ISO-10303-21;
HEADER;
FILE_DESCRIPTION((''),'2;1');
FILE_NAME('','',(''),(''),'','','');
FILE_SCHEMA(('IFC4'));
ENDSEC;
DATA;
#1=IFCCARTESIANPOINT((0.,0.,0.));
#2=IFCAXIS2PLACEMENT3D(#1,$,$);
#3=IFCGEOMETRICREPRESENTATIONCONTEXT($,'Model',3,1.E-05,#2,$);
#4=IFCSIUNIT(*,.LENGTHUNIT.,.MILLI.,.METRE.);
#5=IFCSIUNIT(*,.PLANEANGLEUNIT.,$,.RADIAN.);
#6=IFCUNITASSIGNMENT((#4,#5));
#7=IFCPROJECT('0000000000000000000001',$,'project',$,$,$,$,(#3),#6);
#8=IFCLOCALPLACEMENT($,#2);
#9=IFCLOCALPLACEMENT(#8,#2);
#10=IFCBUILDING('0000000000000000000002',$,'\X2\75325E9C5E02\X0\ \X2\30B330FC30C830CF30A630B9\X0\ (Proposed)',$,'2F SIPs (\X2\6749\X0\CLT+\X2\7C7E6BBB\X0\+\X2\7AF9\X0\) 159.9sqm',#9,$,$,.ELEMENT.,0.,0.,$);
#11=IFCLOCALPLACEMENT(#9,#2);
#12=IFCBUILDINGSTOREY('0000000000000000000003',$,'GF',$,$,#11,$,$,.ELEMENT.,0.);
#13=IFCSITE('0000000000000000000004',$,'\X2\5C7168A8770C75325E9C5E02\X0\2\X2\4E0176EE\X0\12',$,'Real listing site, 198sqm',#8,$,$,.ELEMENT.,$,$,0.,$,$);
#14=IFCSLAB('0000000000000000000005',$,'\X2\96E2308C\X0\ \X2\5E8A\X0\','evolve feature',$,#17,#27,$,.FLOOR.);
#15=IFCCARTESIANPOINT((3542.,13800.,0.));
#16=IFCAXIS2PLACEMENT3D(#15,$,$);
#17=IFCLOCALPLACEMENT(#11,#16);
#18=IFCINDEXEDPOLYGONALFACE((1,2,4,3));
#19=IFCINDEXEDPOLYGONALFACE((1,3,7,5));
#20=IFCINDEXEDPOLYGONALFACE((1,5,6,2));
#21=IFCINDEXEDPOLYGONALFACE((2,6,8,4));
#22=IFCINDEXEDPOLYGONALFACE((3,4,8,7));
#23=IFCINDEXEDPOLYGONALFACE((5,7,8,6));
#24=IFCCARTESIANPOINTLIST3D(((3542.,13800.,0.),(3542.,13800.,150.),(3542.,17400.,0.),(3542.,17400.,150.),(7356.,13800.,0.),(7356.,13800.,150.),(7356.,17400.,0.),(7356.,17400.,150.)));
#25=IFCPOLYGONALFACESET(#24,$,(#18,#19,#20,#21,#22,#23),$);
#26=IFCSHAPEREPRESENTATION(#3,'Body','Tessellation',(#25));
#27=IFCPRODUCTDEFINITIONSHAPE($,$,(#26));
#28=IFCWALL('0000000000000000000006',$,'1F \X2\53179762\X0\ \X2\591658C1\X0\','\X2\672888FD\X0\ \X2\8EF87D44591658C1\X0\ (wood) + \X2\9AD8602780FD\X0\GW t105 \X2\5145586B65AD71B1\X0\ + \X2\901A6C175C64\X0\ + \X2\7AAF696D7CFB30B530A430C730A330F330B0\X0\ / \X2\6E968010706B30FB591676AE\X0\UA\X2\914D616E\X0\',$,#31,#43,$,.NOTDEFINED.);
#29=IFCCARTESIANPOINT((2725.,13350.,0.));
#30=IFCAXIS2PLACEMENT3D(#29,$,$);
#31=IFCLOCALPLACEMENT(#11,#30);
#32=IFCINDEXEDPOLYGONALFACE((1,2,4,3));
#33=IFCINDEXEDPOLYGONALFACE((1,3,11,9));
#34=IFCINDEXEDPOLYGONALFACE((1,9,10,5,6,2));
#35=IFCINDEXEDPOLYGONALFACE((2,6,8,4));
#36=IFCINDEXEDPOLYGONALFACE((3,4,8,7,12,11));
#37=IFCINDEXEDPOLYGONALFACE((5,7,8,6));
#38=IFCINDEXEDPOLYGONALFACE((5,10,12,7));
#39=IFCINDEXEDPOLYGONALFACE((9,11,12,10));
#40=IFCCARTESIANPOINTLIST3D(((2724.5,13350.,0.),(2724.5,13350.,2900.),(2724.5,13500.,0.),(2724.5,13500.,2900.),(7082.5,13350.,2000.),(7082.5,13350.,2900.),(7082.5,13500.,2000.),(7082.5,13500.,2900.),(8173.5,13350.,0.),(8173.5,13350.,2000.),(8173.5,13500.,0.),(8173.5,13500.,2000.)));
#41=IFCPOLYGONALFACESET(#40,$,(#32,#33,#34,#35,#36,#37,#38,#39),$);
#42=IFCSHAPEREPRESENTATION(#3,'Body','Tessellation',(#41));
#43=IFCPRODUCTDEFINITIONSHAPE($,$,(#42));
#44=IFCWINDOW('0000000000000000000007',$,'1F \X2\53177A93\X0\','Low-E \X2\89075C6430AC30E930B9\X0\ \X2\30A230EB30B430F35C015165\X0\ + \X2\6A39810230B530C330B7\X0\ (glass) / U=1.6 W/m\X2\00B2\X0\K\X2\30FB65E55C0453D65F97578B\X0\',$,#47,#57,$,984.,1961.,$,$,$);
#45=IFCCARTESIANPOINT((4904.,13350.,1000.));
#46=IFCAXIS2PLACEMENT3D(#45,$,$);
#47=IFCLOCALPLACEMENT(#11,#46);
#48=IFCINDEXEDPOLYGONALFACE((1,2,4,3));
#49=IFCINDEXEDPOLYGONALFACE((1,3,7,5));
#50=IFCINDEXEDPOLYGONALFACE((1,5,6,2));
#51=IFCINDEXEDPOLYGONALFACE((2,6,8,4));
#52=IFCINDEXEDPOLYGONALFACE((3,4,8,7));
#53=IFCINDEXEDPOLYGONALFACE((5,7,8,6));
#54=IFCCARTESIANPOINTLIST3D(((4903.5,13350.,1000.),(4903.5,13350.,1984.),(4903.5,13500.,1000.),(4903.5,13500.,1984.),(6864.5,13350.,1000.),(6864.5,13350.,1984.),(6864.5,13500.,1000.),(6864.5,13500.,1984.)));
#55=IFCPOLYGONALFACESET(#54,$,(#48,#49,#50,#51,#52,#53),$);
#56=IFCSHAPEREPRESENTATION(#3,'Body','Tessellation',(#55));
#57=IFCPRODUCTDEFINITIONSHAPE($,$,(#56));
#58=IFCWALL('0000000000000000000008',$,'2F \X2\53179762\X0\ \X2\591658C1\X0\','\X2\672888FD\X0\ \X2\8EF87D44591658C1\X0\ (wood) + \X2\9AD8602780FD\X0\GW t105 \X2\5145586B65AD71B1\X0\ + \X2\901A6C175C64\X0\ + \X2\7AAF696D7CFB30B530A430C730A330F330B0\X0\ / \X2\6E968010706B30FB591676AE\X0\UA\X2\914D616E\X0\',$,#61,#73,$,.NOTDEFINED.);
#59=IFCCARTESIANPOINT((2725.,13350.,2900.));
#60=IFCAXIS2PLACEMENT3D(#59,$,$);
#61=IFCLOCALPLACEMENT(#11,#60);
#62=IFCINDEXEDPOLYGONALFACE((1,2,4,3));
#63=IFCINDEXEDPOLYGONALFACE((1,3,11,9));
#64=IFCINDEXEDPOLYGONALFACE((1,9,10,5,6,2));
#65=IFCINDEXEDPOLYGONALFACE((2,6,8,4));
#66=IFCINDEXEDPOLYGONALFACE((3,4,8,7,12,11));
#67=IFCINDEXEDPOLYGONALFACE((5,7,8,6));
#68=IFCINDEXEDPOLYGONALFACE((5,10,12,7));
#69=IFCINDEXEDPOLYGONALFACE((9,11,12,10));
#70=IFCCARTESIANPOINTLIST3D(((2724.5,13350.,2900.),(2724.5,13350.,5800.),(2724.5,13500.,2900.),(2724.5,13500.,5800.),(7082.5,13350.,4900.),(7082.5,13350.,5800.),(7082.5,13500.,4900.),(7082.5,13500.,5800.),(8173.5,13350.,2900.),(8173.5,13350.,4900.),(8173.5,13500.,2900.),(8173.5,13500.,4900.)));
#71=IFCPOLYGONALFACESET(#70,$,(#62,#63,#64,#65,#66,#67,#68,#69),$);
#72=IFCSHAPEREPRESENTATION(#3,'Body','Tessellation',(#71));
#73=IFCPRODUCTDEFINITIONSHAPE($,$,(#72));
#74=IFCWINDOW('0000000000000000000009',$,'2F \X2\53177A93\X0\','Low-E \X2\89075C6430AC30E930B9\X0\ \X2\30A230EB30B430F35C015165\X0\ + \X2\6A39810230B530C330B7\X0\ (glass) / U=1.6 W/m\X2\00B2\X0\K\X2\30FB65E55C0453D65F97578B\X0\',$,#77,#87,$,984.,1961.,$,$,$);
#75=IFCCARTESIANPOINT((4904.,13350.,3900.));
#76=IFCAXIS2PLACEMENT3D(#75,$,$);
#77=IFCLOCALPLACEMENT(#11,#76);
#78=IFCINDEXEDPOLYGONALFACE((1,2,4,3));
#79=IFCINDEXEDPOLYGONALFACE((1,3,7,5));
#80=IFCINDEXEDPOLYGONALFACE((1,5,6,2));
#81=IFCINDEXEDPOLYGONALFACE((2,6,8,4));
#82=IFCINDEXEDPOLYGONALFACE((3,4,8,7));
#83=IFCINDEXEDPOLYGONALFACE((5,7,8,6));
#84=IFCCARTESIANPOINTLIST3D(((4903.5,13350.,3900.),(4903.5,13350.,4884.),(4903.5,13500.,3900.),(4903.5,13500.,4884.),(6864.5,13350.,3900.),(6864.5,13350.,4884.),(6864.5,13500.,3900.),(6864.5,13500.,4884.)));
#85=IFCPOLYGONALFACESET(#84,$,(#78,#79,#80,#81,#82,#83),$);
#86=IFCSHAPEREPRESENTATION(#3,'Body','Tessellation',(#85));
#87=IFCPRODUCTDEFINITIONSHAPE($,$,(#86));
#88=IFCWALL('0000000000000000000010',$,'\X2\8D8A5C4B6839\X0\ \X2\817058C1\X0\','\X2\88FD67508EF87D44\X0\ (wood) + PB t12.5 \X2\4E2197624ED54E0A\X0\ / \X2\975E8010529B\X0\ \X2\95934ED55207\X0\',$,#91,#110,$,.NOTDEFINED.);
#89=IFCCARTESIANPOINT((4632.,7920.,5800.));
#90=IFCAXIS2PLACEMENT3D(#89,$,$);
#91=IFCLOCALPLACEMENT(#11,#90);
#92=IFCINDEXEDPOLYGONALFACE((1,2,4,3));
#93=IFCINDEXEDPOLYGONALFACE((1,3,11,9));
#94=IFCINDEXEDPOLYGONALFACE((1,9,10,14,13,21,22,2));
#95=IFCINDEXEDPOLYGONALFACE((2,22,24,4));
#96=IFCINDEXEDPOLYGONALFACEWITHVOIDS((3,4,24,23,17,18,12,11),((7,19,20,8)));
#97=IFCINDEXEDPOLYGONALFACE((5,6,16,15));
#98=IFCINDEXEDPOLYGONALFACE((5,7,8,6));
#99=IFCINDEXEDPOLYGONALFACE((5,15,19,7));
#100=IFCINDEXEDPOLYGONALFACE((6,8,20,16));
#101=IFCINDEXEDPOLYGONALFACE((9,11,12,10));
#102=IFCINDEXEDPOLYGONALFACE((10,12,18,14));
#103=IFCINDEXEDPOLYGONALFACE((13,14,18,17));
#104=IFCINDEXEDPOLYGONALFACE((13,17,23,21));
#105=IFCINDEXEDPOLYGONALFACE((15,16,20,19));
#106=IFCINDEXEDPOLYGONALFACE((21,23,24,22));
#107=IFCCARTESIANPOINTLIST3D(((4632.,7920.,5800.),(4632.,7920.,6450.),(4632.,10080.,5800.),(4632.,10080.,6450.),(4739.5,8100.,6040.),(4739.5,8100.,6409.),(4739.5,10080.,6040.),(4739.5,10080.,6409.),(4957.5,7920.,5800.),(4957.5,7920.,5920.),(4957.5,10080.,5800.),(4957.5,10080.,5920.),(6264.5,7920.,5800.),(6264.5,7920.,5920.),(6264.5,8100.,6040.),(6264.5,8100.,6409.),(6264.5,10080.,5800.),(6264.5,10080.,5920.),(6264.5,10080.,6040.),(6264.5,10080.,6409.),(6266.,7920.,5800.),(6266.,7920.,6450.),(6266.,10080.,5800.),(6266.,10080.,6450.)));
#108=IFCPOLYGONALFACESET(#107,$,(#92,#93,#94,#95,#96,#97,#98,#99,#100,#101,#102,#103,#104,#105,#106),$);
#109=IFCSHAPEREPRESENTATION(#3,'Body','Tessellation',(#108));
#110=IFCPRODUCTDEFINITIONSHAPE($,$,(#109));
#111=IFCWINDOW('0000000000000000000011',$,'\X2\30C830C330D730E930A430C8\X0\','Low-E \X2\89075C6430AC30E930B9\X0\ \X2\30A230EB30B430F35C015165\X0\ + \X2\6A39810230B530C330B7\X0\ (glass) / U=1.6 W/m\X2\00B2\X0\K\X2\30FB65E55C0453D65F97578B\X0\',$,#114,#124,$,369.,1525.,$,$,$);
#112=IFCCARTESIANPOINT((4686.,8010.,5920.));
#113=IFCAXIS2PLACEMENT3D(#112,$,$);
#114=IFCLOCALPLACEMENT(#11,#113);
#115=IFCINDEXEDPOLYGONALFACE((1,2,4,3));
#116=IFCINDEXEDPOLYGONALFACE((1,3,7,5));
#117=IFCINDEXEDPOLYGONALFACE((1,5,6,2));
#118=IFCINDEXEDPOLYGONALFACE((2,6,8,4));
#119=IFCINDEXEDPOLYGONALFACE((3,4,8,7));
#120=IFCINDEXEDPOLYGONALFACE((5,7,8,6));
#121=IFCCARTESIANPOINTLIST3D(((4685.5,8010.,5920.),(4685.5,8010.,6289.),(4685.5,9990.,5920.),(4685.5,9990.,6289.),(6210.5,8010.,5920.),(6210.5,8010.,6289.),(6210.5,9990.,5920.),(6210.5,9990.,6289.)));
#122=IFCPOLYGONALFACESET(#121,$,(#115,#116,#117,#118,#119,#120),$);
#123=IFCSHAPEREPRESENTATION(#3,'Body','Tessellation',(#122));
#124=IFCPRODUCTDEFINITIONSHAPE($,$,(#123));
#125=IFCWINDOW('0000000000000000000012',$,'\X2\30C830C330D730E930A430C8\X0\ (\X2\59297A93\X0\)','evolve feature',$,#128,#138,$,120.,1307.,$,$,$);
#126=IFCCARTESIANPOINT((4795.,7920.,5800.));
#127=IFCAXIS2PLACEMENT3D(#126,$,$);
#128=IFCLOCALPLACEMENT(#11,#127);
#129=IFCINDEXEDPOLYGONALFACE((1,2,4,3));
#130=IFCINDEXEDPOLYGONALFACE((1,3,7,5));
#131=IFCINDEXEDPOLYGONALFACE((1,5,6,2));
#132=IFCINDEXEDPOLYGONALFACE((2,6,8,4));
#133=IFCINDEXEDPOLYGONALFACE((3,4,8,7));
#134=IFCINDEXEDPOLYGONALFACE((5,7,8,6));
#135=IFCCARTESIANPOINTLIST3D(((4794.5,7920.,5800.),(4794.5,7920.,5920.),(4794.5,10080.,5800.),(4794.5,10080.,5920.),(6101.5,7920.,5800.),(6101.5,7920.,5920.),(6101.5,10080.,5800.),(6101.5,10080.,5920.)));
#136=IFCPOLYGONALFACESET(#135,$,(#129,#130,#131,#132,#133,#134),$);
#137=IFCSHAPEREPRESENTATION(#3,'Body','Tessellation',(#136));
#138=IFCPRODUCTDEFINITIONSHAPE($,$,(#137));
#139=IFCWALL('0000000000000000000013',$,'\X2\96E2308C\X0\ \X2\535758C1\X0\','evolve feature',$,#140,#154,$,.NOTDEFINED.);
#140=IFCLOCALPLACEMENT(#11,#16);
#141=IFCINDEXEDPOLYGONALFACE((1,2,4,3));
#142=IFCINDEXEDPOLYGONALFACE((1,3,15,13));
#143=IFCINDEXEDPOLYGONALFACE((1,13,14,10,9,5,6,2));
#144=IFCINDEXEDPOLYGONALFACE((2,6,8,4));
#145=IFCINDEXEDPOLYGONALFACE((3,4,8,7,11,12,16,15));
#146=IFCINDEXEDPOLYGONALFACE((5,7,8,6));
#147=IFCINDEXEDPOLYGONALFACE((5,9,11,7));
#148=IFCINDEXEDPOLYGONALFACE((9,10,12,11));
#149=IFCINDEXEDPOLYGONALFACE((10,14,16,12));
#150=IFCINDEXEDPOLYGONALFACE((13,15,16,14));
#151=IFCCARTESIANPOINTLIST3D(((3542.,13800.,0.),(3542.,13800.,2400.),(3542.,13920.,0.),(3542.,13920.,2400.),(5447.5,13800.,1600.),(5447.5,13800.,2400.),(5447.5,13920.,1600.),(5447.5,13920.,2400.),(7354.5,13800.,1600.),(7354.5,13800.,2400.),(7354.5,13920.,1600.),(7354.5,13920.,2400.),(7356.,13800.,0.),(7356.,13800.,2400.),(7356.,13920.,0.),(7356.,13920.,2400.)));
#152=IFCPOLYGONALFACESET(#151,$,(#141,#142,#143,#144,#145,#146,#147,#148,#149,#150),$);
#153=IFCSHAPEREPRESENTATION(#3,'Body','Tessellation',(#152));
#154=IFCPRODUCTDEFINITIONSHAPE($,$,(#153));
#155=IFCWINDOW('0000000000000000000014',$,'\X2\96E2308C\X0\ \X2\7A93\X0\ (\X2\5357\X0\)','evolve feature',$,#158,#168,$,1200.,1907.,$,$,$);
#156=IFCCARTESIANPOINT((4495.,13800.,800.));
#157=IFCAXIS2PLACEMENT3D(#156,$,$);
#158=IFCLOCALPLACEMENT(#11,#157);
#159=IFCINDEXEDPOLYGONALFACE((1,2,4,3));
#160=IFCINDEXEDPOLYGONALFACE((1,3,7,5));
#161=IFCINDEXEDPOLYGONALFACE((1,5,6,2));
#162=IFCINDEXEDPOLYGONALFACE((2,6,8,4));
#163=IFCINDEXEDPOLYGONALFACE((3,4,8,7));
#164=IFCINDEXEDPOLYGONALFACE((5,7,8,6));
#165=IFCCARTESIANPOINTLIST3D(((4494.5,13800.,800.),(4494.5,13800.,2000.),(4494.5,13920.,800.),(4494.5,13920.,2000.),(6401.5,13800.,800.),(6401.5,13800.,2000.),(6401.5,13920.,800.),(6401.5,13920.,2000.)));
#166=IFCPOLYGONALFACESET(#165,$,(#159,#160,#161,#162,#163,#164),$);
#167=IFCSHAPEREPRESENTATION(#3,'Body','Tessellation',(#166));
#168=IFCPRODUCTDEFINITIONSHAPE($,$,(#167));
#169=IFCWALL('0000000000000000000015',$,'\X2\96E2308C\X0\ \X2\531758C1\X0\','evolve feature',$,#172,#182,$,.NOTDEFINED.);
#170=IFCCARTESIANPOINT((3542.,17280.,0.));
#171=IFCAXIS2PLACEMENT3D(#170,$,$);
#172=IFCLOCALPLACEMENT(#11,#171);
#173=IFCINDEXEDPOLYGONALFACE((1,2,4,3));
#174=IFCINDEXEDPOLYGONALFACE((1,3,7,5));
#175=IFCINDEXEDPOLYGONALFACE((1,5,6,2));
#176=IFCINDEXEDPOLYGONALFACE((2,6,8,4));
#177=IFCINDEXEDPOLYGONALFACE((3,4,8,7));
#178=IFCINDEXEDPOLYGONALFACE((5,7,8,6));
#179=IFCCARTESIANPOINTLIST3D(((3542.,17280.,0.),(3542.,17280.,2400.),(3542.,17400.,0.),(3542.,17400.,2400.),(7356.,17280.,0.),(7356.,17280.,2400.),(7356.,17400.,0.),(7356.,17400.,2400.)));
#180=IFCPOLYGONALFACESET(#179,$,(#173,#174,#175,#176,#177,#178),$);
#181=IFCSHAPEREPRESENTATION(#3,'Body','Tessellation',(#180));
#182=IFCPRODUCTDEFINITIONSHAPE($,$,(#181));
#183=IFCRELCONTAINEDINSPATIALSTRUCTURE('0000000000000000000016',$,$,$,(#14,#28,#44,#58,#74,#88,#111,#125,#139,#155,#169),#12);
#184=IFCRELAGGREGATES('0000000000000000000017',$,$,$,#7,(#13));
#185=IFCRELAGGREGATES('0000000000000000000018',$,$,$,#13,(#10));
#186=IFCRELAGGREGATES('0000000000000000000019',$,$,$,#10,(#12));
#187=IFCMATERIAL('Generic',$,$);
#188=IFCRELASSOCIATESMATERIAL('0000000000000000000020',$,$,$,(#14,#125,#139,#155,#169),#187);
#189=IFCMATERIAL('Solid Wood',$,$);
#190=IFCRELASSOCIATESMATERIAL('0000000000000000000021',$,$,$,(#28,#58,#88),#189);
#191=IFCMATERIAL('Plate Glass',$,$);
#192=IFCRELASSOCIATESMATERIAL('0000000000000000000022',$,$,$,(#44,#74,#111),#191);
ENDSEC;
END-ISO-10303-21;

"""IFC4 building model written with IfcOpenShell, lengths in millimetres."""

from ifc_helpers import new_model, si_unit, frame, frame_2d, origin, place, context, project, spatial, rectangle, extrude, material, element, fill, save


model = new_model("IFC4")

# Units and contexts
model_context = context("Model", 3, precision=1e-05, world=origin())
ifc_project = project(units=[si_unit("LENGTHUNIT", "METRE", prefix="MILLI"), si_unit("PLANEANGLEUNIT", "RADIAN")], contexts=[model_context])

# Site, building, storey
site_placement = place(None, origin())
site = spatial("IfcSite", under=ifc_project, at=site_placement, Name="山梨県甲府市2丁目12", ObjectType="Real listing site, 198sqm", CompositionType="ELEMENT", RefElevation=0.0)
building_placement = place(site_placement, origin())
building = spatial("IfcBuilding", under=site, at=building_placement, Name="甲府市 コートハウス (Proposed)", ObjectType="2F SIPs (杉CLT+籾殻+竹) 159.9sqm", CompositionType="ELEMENT", ElevationOfRefHeight=0.0, ElevationOfTerrain=0.0)
storey_placement = place(building_placement, origin())
storey = spatial("IfcBuildingStorey", under=building, at=storey_placement, Name="GF", CompositionType="ELEMENT", Elevation=0.0)

# Slab
ifc_material_1 = material(Name="Generic")
slab_placement = place(storey_placement, frame((3542.0, 13800.0, 0.0)))
element("IfcSlab", 1, at=slab_placement, inside=storey, material=ifc_material_1, Name="離れ 床", Description="evolve feature", PredefinedType="FLOOR", context=model_context, shape_type="SweptSolid", body=[
    extrude(rectangle(XDim=3814.0, YDim=3600.0, at=frame_2d((1907.0, 1800.0))), frame((3542.0, 13800.0, 0.0)), (0.0, 0.0, 1.0), 150.0),
])

# Wall, opening, window
ifc_material_2 = material(Name="Solid Wood")
wall_1_placement = place(storey_placement, frame((2725.0, 13350.0, 0.0)))
wall_1 = element("IfcWall", 2, at=wall_1_placement, inside=storey, material=ifc_material_2, Name="1F 北面 外壁", Description="木製 軸組外壁 (wood) + 高性能GW t105 充填断熱 + 通気層 + 窯業系サイディング / 準耐火・外皮UA配慮", PredefinedType="NOTDEFINED", context=model_context, shape_type="SweptSolid", body=[
    extrude(rectangle(XDim=5449.0, YDim=150.0, at=frame_2d((2724.0, 75.0))), frame((2725.0, 13350.0, 0.0)), (0.0, 0.0, 1.0), 2900.0),
])
opening_1_placement = place(storey_placement, frame((4904.0, 13350.0, 1000.0)))
opening_1 = element("IfcOpeningElement", 3, at=opening_1_placement, cuts=wall_1, PredefinedType="NOTDEFINED", context=model_context, shape_type="SweptSolid", body=[
    extrude(rectangle(XDim=1961.0, YDim=150.0, at=frame_2d((980.0, 75.0))), frame((4904.0, 13350.0, 1000.0)), (0.0, 0.0, 1.0), 984.0),
])
ifc_material_3 = material(Name="Plate Glass")
window_1_placement = place(storey_placement, frame((4904.0, 13350.0, 1000.0)))
window_1 = element("IfcWindow", 4, at=window_1_placement, inside=storey, material=ifc_material_3, Name="1F 北窓", Description="Low-E 複層ガラス アルゴン封入 + 樹脂サッシ (glass) / U=1.6 W/m²K・日射取得型", OverallHeight=984.0, OverallWidth=1961.0, context=model_context, shape_type="SweptSolid", body=[
    extrude(rectangle(XDim=1961.0, YDim=150.0, at=frame_2d((980.0, 75.0))), frame((4904.0, 13350.0, 1000.0)), (0.0, 0.0, 1.0), 984.0),
])
fill(opening_1, window_1)

# Wall, opening, window
wall_2_placement = place(storey_placement, frame((2725.0, 13350.0, 2900.0)))
wall_2 = element("IfcWall", 5, at=wall_2_placement, inside=storey, material=ifc_material_2, Name="2F 北面 外壁", Description="木製 軸組外壁 (wood) + 高性能GW t105 充填断熱 + 通気層 + 窯業系サイディング / 準耐火・外皮UA配慮", PredefinedType="NOTDEFINED", context=model_context, shape_type="SweptSolid", body=[
    extrude(rectangle(XDim=5449.0, YDim=150.0, at=frame_2d((2724.0, 75.0))), frame((2725.0, 13350.0, 2900.0)), (0.0, 0.0, 1.0), 2900.0),
])
opening_2_placement = place(storey_placement, frame((4904.0, 13350.0, 3900.0)))
opening_2 = element("IfcOpeningElement", 6, at=opening_2_placement, cuts=wall_2, PredefinedType="NOTDEFINED", context=model_context, shape_type="SweptSolid", body=[
    extrude(rectangle(XDim=1961.0, YDim=150.0, at=frame_2d((980.0, 75.0))), frame((4904.0, 13350.0, 3900.0)), (0.0, 0.0, 1.0), 984.0),
])
window_2_placement = place(storey_placement, frame((4904.0, 13350.0, 3900.0)))
window_2 = element("IfcWindow", 7, at=window_2_placement, inside=storey, material=ifc_material_3, Name="2F 北窓", Description="Low-E 複層ガラス アルゴン封入 + 樹脂サッシ (glass) / U=1.6 W/m²K・日射取得型", OverallHeight=984.0, OverallWidth=1961.0, context=model_context, shape_type="SweptSolid", body=[
    extrude(rectangle(XDim=1961.0, YDim=150.0, at=frame_2d((980.0, 75.0))), frame((4904.0, 13350.0, 3900.0)), (0.0, 0.0, 1.0), 984.0),
])
fill(opening_2, window_2)

# Wall, openings, windows
wall_3_placement = place(storey_placement, frame((4632.0, 7920.0, 5800.0)))
wall_3 = element("IfcWall", 8, at=wall_3_placement, inside=storey, material=ifc_material_2, Name="越屋根 腰壁", Description="製材軸組 (wood) + PB t12.5 両面仕上 / 非耐力 間仕切", PredefinedType="NOTDEFINED", context=model_context, shape_type="SweptSolid", body=[
    extrude(rectangle(XDim=1634.0, YDim=2160.0, at=frame_2d((817.0, 1080.0))), frame((4632.0, 7920.0, 5800.0)), (0.0, 0.0, 1.0), 650.0),
])
opening_3_placement = place(storey_placement, frame((4686.0, 8010.0, 5920.0)))
opening_3 = element("IfcOpeningElement", 9, at=opening_3_placement, cuts=wall_3, PredefinedType="NOTDEFINED", context=model_context, shape_type="SweptSolid", body=[
    extrude(rectangle(XDim=1525.0, YDim=1980.0, at=frame_2d((762.0, 990.0))), frame((4686.0, 8010.0, 5920.0)), (0.0, 0.0, 1.0), 369.0),
])
opening_4_placement = place(storey_placement, frame((4795.0, 7920.0, 5800.0)))
opening_4 = element("IfcOpeningElement", 10, at=opening_4_placement, cuts=wall_3, PredefinedType="NOTDEFINED", context=model_context, shape_type="SweptSolid", body=[
    extrude(rectangle(XDim=1307.0, YDim=2160.0, at=frame_2d((653.0, 1080.0))), frame((4795.0, 7920.0, 5800.0)), (0.0, 0.0, 1.0), 120.0),
])
window_3_placement = place(storey_placement, frame((4686.0, 8010.0, 5920.0)))
window_3 = element("IfcWindow", 11, at=window_3_placement, inside=storey, material=ifc_material_3, Name="トップライト", Description="Low-E 複層ガラス アルゴン封入 + 樹脂サッシ (glass) / U=1.6 W/m²K・日射取得型", OverallHeight=369.0, OverallWidth=1525.0, context=model_context, shape_type="SweptSolid", body=[
    extrude(rectangle(XDim=1525.0, YDim=1980.0, at=frame_2d((762.0, 990.0))), frame((4686.0, 8010.0, 5920.0)), (0.0, 0.0, 1.0), 369.0),
])
fill(opening_3, window_3)
window_4_placement = place(storey_placement, frame((4795.0, 7920.0, 5800.0)))
window_4 = element("IfcWindow", 12, at=window_4_placement, inside=storey, material=ifc_material_1, Name="トップライト (天窓)", Description="evolve feature", OverallHeight=120.0, OverallWidth=1307.0, context=model_context, shape_type="SweptSolid", body=[
    extrude(rectangle(XDim=1307.0, YDim=2160.0, at=frame_2d((653.0, 1080.0))), frame((4795.0, 7920.0, 5800.0)), (0.0, 0.0, 1.0), 120.0),
])
fill(opening_4, window_4)

# Wall, opening, window
wall_4_placement = place(storey_placement, frame((3542.0, 13800.0, 0.0)))
wall_4 = element("IfcWall", 13, at=wall_4_placement, inside=storey, material=ifc_material_1, Name="離れ 南壁", Description="evolve feature", PredefinedType="NOTDEFINED", context=model_context, shape_type="SweptSolid", body=[
    extrude(rectangle(XDim=3814.0, YDim=120.0, at=frame_2d((1907.0, 60.0))), frame((3542.0, 13800.0, 0.0)), (0.0, 0.0, 1.0), 2400.0),
])
opening_5_placement = place(storey_placement, frame((4495.0, 13800.0, 800.0)))
opening_5 = element("IfcOpeningElement", 14, at=opening_5_placement, cuts=wall_4, PredefinedType="NOTDEFINED", context=model_context, shape_type="SweptSolid", body=[
    extrude(rectangle(XDim=1907.0, YDim=120.0, at=frame_2d((953.0, 60.0))), frame((4495.0, 13800.0, 800.0)), (0.0, 0.0, 1.0), 1200.0),
])
window_5_placement = place(storey_placement, frame((4495.0, 13800.0, 800.0)))
window_5 = element("IfcWindow", 15, at=window_5_placement, inside=storey, material=ifc_material_1, Name="離れ 窓 (南)", Description="evolve feature", OverallHeight=1200.0, OverallWidth=1907.0, context=model_context, shape_type="SweptSolid", body=[
    extrude(rectangle(XDim=1907.0, YDim=120.0, at=frame_2d((953.0, 60.0))), frame((4495.0, 13800.0, 800.0)), (0.0, 0.0, 1.0), 1200.0),
])
fill(opening_5, window_5)

# Wall
wall_5_placement = place(storey_placement, frame((3542.0, 17280.0, 0.0)))
element("IfcWall", 16, at=wall_5_placement, inside=storey, material=ifc_material_1, Name="離れ 北壁", Description="evolve feature", PredefinedType="NOTDEFINED", context=model_context, shape_type="SweptSolid", body=[
    extrude(rectangle(XDim=3814.0, YDim=120.0, at=frame_2d((1907.0, 60.0))), frame((3542.0, 17280.0, 0.0)), (0.0, 0.0, 1.0), 2400.0),
])

save(model, "model.ifc")
